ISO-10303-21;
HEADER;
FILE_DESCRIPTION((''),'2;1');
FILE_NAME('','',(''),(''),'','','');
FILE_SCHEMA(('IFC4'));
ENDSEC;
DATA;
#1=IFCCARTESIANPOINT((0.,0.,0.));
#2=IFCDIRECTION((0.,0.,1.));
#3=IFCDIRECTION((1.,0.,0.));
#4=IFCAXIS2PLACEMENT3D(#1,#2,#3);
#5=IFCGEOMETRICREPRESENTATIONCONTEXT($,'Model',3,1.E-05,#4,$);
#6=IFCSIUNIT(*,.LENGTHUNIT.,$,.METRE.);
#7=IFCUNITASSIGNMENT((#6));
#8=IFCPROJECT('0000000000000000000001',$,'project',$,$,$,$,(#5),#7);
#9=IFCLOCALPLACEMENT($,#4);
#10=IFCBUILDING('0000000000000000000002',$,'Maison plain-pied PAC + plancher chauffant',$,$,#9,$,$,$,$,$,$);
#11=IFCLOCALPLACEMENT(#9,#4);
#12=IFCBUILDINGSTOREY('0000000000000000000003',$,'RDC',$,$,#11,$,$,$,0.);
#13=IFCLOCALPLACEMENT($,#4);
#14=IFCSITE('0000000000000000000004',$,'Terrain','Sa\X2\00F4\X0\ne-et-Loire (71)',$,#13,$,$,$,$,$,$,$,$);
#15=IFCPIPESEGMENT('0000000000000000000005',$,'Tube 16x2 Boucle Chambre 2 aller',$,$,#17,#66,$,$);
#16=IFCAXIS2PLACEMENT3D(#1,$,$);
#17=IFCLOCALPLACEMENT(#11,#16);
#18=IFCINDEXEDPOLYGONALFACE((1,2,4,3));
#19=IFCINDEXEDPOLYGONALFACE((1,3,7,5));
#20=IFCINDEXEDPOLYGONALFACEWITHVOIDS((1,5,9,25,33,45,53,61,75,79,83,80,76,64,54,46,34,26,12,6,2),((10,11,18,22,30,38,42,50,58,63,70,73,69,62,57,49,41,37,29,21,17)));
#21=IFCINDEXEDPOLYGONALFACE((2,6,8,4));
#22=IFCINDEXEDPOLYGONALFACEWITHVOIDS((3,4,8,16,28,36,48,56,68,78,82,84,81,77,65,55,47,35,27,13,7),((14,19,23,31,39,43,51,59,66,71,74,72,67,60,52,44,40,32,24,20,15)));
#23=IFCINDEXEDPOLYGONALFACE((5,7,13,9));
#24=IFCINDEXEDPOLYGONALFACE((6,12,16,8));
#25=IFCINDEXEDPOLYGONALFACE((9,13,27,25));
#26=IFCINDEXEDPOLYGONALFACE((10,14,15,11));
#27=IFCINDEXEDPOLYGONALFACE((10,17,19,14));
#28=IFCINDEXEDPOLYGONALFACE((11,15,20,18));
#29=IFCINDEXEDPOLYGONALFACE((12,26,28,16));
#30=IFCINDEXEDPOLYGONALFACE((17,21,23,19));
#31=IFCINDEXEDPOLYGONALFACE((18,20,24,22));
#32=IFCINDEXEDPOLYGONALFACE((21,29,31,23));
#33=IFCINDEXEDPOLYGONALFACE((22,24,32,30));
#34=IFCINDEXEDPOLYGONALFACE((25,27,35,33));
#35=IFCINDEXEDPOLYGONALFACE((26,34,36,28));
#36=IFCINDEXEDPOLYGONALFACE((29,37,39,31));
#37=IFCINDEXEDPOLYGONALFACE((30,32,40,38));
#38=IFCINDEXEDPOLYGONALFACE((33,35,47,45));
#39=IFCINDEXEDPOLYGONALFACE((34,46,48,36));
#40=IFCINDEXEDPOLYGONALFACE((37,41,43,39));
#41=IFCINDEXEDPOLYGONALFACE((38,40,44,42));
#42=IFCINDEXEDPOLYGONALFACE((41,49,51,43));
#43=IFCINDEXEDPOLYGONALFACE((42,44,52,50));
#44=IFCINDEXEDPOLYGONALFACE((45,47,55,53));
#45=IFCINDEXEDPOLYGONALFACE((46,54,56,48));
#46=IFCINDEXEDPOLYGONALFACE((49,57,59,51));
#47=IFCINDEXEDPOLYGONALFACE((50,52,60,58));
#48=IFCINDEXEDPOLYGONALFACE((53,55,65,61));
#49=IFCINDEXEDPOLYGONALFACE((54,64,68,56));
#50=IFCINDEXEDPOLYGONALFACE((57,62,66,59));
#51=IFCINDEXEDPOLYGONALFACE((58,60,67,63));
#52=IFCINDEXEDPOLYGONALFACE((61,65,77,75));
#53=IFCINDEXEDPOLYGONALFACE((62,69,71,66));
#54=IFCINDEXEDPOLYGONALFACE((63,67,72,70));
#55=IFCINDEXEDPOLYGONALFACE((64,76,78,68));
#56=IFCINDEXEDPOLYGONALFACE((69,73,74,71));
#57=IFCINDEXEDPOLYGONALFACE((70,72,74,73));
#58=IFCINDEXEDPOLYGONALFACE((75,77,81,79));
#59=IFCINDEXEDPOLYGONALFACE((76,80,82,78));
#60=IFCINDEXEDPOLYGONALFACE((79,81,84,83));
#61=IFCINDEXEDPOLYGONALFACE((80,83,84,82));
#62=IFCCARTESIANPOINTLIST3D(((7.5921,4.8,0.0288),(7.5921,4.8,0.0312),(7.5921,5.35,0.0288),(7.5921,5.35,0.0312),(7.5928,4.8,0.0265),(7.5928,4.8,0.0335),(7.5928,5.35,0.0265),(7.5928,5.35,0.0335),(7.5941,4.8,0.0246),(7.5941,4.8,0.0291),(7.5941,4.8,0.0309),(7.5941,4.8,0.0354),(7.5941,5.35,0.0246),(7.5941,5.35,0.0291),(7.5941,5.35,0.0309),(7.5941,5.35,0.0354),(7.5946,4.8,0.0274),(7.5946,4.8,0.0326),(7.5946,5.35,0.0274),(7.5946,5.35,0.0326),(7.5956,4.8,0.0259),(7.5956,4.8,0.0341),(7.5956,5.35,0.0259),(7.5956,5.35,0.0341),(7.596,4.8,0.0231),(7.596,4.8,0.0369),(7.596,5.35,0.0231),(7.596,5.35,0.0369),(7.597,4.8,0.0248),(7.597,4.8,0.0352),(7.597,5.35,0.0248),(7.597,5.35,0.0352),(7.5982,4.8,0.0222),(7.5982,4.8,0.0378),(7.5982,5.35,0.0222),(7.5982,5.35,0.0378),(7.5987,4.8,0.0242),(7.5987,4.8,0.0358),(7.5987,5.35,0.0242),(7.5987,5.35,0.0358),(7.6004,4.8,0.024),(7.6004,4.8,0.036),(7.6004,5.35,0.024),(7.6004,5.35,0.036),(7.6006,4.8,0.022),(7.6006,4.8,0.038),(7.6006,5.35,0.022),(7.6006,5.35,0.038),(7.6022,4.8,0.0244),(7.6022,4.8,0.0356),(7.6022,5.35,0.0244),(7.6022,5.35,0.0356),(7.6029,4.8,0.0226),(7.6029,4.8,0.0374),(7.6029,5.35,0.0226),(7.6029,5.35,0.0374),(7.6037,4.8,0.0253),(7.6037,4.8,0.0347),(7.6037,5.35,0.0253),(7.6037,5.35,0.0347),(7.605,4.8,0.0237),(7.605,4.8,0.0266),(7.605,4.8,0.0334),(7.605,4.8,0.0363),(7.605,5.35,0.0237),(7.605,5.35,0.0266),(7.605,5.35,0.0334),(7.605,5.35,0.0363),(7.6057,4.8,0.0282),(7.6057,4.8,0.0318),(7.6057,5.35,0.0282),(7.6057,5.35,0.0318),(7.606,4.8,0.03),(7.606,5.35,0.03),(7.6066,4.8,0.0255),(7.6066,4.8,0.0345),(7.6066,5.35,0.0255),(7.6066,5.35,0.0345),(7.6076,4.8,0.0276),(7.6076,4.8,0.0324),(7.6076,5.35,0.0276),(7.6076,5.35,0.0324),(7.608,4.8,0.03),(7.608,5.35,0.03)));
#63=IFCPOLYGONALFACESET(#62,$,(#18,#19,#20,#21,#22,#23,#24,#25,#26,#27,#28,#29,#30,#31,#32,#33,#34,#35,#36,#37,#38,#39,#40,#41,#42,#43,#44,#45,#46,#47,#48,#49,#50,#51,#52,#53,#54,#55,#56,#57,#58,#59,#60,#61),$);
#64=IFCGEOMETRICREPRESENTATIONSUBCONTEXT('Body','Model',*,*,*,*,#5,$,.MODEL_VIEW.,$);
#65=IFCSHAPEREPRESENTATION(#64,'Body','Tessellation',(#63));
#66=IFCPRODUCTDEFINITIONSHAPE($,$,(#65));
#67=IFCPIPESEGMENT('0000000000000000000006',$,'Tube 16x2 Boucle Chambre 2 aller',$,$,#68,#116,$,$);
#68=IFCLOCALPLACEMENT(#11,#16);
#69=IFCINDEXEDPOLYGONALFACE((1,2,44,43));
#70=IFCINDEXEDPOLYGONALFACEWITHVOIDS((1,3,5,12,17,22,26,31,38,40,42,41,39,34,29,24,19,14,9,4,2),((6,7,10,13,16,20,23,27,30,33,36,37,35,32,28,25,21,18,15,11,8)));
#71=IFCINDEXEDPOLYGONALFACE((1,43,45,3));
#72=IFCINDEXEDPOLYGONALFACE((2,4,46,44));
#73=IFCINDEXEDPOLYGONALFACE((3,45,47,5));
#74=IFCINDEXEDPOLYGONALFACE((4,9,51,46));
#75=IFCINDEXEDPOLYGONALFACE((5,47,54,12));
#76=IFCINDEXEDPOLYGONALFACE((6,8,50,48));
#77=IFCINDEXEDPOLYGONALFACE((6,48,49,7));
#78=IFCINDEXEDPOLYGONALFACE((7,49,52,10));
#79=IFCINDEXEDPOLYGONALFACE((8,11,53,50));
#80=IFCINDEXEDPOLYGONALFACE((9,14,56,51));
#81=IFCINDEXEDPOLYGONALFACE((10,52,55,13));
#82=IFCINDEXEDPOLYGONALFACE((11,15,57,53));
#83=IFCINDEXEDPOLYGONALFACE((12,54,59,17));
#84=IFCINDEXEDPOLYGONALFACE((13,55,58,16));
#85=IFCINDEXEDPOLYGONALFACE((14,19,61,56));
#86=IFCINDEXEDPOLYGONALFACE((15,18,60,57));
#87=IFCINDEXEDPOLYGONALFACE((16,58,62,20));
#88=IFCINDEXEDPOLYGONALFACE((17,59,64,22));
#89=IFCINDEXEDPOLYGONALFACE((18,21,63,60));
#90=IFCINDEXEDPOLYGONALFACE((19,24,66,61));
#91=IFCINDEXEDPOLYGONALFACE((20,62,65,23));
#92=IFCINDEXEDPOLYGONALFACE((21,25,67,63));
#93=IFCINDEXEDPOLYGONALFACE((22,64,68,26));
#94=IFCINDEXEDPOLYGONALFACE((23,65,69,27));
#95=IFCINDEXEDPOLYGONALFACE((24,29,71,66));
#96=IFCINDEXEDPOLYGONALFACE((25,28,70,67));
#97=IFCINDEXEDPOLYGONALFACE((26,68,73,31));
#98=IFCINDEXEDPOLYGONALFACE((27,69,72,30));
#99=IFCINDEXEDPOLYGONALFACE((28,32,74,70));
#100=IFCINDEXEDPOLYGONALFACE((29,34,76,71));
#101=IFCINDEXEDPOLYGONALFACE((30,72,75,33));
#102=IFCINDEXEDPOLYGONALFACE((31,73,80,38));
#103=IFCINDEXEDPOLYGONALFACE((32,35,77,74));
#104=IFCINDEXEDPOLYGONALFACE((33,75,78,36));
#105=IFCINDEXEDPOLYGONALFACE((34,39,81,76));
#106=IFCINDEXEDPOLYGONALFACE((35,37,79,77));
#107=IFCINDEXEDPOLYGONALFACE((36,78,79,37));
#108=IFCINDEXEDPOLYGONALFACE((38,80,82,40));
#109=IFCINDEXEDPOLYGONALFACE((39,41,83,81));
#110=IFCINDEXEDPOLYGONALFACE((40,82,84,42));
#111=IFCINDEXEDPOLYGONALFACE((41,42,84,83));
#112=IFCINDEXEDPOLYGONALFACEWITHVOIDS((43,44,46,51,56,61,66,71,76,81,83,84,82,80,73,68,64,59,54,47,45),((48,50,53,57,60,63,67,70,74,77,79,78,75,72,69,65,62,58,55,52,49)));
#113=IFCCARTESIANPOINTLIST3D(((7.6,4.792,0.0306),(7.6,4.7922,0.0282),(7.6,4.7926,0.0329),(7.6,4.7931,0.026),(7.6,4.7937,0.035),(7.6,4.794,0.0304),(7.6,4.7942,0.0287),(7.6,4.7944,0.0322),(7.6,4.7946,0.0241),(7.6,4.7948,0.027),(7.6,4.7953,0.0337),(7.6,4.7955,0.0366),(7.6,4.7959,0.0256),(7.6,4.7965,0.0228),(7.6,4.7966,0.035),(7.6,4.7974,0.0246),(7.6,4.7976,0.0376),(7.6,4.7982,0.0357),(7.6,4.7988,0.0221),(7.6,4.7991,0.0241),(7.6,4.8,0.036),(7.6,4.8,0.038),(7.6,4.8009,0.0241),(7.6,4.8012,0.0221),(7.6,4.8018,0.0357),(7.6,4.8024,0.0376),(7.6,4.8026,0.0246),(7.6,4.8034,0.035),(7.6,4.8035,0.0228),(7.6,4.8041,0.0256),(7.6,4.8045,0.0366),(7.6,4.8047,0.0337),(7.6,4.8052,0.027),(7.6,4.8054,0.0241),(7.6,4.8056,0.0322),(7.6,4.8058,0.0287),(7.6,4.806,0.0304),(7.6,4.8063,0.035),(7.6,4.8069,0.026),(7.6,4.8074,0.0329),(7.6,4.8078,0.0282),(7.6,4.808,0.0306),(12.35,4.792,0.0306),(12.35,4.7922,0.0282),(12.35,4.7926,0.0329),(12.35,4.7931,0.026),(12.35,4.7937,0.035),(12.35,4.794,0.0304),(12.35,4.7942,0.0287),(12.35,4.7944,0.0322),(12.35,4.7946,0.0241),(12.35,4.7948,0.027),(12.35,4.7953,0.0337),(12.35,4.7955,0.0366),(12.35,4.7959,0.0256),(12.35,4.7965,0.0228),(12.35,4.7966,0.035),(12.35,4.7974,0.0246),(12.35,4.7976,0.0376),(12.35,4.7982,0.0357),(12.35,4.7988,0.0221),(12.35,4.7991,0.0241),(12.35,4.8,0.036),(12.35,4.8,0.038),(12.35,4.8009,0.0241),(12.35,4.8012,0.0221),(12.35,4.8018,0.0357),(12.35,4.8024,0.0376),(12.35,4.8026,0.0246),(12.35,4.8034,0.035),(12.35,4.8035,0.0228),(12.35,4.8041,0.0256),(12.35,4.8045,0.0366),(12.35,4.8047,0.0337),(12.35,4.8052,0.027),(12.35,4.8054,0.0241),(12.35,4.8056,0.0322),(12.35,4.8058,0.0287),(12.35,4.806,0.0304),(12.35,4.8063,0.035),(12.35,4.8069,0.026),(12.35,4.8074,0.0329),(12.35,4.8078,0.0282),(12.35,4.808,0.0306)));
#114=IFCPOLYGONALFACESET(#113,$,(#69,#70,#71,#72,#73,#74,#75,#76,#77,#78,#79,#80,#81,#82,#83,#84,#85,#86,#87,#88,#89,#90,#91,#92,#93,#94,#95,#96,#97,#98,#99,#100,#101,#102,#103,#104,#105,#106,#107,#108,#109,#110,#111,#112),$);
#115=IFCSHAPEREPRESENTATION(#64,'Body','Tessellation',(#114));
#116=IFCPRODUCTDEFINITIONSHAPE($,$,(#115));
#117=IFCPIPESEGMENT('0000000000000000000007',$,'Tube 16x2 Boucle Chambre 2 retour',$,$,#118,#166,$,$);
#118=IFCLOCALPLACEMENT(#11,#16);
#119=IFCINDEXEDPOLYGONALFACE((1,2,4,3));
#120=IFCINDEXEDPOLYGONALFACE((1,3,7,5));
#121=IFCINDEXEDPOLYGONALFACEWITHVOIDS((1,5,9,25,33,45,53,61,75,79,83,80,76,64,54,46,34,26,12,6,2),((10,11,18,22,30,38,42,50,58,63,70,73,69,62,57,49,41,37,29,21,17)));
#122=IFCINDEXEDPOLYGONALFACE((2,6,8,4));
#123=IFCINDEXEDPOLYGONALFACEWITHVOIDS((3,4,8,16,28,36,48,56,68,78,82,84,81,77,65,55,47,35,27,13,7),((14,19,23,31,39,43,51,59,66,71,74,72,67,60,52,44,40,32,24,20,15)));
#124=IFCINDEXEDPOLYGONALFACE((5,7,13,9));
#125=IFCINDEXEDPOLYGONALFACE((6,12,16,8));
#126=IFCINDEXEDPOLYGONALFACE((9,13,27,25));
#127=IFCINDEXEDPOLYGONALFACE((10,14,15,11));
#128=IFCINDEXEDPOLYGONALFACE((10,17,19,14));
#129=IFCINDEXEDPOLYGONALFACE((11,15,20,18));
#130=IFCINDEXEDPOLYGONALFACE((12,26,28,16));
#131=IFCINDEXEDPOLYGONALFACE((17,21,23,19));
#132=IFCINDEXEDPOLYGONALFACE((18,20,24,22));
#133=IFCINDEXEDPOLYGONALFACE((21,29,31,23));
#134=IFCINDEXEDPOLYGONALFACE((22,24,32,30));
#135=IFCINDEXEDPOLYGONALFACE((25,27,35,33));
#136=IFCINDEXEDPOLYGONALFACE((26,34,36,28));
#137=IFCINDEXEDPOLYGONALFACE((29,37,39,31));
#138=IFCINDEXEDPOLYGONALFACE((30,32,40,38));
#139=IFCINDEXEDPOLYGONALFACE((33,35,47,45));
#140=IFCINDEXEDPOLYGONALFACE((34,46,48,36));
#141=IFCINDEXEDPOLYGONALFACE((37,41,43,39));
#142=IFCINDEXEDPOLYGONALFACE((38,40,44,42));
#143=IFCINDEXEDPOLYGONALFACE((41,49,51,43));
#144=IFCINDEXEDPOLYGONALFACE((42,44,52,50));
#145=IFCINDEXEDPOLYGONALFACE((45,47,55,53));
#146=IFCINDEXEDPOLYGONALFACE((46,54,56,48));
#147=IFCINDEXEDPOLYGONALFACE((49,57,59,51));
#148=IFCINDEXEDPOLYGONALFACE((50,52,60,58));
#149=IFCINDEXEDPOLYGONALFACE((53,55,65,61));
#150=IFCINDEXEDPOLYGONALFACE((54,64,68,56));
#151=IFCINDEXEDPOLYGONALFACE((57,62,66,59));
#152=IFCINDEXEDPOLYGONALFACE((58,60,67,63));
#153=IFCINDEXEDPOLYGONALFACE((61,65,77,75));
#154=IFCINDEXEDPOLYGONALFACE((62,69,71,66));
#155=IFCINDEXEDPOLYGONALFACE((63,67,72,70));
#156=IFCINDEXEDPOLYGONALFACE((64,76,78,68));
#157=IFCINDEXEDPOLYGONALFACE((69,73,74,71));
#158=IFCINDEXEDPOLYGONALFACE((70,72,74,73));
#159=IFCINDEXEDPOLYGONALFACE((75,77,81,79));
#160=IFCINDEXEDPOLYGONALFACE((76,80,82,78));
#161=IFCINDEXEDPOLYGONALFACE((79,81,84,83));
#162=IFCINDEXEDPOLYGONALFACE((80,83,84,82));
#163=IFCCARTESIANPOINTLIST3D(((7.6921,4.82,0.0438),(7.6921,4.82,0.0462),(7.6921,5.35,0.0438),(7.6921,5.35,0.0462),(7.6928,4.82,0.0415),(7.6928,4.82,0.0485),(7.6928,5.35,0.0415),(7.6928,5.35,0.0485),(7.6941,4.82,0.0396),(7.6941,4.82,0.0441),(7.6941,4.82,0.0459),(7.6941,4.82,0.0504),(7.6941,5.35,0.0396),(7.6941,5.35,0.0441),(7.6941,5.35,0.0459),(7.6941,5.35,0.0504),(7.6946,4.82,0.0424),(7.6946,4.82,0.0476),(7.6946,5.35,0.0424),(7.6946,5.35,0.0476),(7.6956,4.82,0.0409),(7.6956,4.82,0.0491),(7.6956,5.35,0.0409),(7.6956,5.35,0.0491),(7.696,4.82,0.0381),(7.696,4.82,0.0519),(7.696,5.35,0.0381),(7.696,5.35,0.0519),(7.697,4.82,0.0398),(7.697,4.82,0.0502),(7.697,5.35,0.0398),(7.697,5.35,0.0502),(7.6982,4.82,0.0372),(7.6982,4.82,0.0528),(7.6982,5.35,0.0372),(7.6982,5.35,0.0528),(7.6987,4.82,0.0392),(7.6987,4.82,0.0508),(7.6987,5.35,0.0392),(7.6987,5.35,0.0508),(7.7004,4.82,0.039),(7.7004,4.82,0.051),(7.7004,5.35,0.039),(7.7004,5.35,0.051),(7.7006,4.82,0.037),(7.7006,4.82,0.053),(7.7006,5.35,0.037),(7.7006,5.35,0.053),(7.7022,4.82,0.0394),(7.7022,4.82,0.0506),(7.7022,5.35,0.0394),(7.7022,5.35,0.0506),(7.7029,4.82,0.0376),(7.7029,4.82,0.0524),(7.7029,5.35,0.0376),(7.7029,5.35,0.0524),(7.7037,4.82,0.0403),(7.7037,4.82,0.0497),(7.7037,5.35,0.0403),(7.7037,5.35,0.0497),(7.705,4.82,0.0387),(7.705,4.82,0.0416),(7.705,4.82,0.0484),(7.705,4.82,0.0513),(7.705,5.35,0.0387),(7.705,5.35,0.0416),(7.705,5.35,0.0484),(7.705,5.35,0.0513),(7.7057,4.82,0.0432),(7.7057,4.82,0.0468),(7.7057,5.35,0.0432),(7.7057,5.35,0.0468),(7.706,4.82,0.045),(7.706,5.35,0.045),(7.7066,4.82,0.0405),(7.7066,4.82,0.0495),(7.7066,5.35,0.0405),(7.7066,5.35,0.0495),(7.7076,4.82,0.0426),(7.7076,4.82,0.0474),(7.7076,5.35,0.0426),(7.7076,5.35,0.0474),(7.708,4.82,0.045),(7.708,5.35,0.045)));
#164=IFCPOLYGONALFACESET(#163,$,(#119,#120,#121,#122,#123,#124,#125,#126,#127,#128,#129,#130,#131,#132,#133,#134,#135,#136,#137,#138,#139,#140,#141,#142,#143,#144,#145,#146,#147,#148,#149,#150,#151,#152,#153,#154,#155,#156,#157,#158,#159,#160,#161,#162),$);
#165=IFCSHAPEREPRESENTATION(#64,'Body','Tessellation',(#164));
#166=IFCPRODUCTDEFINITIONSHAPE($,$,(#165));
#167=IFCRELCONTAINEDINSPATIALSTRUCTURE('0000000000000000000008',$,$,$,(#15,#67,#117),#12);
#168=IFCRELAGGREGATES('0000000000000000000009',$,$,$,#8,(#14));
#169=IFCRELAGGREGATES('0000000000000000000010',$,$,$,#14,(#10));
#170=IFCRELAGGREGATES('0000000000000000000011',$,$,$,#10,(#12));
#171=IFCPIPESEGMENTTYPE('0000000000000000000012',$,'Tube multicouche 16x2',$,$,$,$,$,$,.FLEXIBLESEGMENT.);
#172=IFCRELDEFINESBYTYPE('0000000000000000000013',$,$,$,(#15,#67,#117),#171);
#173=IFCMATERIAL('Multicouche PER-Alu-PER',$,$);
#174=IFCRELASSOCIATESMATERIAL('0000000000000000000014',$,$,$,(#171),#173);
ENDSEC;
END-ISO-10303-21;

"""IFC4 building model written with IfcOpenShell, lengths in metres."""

from ifc_helpers import new_model, si_unit, frame, origin_with_axes, place, context, subcontext, project, spatial, hollow_circle, extrude, material, type_object, element, save


model = new_model("IFC4")

# Units and contexts
model_context = context("Model", 3, precision=1e-05, world=origin_with_axes())
body_context = subcontext(model_context, "Body", "Model", "MODEL_VIEW")
ifc_project = project(units=[si_unit("LENGTHUNIT", "METRE")], contexts=[model_context])

# Site, building, storey
site_placement = place(None, origin_with_axes())
site = spatial("IfcSite", under=ifc_project, at=site_placement, Name="Terrain", Description="Saône-et-Loire (71)")
building_placement = place(None, origin_with_axes())
building = spatial("IfcBuilding", under=site, at=building_placement, Name="Maison plain-pied PAC + plancher chauffant")
storey_placement = place(building_placement, origin_with_axes())
storey = spatial("IfcBuildingStorey", under=building, at=storey_placement, Name="RDC", Elevation=0.0)

# Pipe segments
ifc_material_1 = material(Name="Multicouche PER-Alu-PER")
pipe_segment_type_1 = type_object("IfcPipeSegmentType", Name="Tube multicouche 16x2", PredefinedType="FLEXIBLESEGMENT", material=ifc_material_1)
pipe_segment_1_placement = place(storey_placement, frame((7.6, 5.35, 0.03), z_axis=(0.0, -1.0, 0.0), x_axis=(1.0, 0.0, 0.0)))
element("IfcPipeSegment", 1, at=pipe_segment_1_placement, inside=storey, type_object=pipe_segment_type_1, Name="Tube 16x2 Boucle Chambre 2 aller", context=body_context, shape_type="SweptSolid", body=[
    extrude(hollow_circle(Radius=0.008, WallThickness=0.002), origin_with_axes(), (0.0, 0.0, 1.0), 0.55),
])
pipe_segment_2_placement = place(storey_placement, frame((7.6, 4.8, 0.03), z_axis=(1.0, 0.0, 0.0), x_axis=(0.0, 0.0, 1.0)))
element("IfcPipeSegment", 2, at=pipe_segment_2_placement, inside=storey, type_object=pipe_segment_type_1, Name="Tube 16x2 Boucle Chambre 2 aller", context=body_context, shape_type="SweptSolid", body=[
    extrude(hollow_circle(Radius=0.008, WallThickness=0.002), origin_with_axes(), (0.0, 0.0, 1.0), 4.75),
])
pipe_segment_3_placement = place(storey_placement, frame((7.7, 4.82, 0.045), z_axis=(0.0, 1.0, 0.0), x_axis=(1.0, 0.0, 0.0)))
element("IfcPipeSegment", 3, at=pipe_segment_3_placement, inside=storey, type_object=pipe_segment_type_1, Name="Tube 16x2 Boucle Chambre 2 retour", context=body_context, shape_type="SweptSolid", body=[
    extrude(hollow_circle(Radius=0.008, WallThickness=0.002), origin_with_axes(), (0.0, 0.0, 1.0), 0.53),
])

save(model, "model.ifc")
